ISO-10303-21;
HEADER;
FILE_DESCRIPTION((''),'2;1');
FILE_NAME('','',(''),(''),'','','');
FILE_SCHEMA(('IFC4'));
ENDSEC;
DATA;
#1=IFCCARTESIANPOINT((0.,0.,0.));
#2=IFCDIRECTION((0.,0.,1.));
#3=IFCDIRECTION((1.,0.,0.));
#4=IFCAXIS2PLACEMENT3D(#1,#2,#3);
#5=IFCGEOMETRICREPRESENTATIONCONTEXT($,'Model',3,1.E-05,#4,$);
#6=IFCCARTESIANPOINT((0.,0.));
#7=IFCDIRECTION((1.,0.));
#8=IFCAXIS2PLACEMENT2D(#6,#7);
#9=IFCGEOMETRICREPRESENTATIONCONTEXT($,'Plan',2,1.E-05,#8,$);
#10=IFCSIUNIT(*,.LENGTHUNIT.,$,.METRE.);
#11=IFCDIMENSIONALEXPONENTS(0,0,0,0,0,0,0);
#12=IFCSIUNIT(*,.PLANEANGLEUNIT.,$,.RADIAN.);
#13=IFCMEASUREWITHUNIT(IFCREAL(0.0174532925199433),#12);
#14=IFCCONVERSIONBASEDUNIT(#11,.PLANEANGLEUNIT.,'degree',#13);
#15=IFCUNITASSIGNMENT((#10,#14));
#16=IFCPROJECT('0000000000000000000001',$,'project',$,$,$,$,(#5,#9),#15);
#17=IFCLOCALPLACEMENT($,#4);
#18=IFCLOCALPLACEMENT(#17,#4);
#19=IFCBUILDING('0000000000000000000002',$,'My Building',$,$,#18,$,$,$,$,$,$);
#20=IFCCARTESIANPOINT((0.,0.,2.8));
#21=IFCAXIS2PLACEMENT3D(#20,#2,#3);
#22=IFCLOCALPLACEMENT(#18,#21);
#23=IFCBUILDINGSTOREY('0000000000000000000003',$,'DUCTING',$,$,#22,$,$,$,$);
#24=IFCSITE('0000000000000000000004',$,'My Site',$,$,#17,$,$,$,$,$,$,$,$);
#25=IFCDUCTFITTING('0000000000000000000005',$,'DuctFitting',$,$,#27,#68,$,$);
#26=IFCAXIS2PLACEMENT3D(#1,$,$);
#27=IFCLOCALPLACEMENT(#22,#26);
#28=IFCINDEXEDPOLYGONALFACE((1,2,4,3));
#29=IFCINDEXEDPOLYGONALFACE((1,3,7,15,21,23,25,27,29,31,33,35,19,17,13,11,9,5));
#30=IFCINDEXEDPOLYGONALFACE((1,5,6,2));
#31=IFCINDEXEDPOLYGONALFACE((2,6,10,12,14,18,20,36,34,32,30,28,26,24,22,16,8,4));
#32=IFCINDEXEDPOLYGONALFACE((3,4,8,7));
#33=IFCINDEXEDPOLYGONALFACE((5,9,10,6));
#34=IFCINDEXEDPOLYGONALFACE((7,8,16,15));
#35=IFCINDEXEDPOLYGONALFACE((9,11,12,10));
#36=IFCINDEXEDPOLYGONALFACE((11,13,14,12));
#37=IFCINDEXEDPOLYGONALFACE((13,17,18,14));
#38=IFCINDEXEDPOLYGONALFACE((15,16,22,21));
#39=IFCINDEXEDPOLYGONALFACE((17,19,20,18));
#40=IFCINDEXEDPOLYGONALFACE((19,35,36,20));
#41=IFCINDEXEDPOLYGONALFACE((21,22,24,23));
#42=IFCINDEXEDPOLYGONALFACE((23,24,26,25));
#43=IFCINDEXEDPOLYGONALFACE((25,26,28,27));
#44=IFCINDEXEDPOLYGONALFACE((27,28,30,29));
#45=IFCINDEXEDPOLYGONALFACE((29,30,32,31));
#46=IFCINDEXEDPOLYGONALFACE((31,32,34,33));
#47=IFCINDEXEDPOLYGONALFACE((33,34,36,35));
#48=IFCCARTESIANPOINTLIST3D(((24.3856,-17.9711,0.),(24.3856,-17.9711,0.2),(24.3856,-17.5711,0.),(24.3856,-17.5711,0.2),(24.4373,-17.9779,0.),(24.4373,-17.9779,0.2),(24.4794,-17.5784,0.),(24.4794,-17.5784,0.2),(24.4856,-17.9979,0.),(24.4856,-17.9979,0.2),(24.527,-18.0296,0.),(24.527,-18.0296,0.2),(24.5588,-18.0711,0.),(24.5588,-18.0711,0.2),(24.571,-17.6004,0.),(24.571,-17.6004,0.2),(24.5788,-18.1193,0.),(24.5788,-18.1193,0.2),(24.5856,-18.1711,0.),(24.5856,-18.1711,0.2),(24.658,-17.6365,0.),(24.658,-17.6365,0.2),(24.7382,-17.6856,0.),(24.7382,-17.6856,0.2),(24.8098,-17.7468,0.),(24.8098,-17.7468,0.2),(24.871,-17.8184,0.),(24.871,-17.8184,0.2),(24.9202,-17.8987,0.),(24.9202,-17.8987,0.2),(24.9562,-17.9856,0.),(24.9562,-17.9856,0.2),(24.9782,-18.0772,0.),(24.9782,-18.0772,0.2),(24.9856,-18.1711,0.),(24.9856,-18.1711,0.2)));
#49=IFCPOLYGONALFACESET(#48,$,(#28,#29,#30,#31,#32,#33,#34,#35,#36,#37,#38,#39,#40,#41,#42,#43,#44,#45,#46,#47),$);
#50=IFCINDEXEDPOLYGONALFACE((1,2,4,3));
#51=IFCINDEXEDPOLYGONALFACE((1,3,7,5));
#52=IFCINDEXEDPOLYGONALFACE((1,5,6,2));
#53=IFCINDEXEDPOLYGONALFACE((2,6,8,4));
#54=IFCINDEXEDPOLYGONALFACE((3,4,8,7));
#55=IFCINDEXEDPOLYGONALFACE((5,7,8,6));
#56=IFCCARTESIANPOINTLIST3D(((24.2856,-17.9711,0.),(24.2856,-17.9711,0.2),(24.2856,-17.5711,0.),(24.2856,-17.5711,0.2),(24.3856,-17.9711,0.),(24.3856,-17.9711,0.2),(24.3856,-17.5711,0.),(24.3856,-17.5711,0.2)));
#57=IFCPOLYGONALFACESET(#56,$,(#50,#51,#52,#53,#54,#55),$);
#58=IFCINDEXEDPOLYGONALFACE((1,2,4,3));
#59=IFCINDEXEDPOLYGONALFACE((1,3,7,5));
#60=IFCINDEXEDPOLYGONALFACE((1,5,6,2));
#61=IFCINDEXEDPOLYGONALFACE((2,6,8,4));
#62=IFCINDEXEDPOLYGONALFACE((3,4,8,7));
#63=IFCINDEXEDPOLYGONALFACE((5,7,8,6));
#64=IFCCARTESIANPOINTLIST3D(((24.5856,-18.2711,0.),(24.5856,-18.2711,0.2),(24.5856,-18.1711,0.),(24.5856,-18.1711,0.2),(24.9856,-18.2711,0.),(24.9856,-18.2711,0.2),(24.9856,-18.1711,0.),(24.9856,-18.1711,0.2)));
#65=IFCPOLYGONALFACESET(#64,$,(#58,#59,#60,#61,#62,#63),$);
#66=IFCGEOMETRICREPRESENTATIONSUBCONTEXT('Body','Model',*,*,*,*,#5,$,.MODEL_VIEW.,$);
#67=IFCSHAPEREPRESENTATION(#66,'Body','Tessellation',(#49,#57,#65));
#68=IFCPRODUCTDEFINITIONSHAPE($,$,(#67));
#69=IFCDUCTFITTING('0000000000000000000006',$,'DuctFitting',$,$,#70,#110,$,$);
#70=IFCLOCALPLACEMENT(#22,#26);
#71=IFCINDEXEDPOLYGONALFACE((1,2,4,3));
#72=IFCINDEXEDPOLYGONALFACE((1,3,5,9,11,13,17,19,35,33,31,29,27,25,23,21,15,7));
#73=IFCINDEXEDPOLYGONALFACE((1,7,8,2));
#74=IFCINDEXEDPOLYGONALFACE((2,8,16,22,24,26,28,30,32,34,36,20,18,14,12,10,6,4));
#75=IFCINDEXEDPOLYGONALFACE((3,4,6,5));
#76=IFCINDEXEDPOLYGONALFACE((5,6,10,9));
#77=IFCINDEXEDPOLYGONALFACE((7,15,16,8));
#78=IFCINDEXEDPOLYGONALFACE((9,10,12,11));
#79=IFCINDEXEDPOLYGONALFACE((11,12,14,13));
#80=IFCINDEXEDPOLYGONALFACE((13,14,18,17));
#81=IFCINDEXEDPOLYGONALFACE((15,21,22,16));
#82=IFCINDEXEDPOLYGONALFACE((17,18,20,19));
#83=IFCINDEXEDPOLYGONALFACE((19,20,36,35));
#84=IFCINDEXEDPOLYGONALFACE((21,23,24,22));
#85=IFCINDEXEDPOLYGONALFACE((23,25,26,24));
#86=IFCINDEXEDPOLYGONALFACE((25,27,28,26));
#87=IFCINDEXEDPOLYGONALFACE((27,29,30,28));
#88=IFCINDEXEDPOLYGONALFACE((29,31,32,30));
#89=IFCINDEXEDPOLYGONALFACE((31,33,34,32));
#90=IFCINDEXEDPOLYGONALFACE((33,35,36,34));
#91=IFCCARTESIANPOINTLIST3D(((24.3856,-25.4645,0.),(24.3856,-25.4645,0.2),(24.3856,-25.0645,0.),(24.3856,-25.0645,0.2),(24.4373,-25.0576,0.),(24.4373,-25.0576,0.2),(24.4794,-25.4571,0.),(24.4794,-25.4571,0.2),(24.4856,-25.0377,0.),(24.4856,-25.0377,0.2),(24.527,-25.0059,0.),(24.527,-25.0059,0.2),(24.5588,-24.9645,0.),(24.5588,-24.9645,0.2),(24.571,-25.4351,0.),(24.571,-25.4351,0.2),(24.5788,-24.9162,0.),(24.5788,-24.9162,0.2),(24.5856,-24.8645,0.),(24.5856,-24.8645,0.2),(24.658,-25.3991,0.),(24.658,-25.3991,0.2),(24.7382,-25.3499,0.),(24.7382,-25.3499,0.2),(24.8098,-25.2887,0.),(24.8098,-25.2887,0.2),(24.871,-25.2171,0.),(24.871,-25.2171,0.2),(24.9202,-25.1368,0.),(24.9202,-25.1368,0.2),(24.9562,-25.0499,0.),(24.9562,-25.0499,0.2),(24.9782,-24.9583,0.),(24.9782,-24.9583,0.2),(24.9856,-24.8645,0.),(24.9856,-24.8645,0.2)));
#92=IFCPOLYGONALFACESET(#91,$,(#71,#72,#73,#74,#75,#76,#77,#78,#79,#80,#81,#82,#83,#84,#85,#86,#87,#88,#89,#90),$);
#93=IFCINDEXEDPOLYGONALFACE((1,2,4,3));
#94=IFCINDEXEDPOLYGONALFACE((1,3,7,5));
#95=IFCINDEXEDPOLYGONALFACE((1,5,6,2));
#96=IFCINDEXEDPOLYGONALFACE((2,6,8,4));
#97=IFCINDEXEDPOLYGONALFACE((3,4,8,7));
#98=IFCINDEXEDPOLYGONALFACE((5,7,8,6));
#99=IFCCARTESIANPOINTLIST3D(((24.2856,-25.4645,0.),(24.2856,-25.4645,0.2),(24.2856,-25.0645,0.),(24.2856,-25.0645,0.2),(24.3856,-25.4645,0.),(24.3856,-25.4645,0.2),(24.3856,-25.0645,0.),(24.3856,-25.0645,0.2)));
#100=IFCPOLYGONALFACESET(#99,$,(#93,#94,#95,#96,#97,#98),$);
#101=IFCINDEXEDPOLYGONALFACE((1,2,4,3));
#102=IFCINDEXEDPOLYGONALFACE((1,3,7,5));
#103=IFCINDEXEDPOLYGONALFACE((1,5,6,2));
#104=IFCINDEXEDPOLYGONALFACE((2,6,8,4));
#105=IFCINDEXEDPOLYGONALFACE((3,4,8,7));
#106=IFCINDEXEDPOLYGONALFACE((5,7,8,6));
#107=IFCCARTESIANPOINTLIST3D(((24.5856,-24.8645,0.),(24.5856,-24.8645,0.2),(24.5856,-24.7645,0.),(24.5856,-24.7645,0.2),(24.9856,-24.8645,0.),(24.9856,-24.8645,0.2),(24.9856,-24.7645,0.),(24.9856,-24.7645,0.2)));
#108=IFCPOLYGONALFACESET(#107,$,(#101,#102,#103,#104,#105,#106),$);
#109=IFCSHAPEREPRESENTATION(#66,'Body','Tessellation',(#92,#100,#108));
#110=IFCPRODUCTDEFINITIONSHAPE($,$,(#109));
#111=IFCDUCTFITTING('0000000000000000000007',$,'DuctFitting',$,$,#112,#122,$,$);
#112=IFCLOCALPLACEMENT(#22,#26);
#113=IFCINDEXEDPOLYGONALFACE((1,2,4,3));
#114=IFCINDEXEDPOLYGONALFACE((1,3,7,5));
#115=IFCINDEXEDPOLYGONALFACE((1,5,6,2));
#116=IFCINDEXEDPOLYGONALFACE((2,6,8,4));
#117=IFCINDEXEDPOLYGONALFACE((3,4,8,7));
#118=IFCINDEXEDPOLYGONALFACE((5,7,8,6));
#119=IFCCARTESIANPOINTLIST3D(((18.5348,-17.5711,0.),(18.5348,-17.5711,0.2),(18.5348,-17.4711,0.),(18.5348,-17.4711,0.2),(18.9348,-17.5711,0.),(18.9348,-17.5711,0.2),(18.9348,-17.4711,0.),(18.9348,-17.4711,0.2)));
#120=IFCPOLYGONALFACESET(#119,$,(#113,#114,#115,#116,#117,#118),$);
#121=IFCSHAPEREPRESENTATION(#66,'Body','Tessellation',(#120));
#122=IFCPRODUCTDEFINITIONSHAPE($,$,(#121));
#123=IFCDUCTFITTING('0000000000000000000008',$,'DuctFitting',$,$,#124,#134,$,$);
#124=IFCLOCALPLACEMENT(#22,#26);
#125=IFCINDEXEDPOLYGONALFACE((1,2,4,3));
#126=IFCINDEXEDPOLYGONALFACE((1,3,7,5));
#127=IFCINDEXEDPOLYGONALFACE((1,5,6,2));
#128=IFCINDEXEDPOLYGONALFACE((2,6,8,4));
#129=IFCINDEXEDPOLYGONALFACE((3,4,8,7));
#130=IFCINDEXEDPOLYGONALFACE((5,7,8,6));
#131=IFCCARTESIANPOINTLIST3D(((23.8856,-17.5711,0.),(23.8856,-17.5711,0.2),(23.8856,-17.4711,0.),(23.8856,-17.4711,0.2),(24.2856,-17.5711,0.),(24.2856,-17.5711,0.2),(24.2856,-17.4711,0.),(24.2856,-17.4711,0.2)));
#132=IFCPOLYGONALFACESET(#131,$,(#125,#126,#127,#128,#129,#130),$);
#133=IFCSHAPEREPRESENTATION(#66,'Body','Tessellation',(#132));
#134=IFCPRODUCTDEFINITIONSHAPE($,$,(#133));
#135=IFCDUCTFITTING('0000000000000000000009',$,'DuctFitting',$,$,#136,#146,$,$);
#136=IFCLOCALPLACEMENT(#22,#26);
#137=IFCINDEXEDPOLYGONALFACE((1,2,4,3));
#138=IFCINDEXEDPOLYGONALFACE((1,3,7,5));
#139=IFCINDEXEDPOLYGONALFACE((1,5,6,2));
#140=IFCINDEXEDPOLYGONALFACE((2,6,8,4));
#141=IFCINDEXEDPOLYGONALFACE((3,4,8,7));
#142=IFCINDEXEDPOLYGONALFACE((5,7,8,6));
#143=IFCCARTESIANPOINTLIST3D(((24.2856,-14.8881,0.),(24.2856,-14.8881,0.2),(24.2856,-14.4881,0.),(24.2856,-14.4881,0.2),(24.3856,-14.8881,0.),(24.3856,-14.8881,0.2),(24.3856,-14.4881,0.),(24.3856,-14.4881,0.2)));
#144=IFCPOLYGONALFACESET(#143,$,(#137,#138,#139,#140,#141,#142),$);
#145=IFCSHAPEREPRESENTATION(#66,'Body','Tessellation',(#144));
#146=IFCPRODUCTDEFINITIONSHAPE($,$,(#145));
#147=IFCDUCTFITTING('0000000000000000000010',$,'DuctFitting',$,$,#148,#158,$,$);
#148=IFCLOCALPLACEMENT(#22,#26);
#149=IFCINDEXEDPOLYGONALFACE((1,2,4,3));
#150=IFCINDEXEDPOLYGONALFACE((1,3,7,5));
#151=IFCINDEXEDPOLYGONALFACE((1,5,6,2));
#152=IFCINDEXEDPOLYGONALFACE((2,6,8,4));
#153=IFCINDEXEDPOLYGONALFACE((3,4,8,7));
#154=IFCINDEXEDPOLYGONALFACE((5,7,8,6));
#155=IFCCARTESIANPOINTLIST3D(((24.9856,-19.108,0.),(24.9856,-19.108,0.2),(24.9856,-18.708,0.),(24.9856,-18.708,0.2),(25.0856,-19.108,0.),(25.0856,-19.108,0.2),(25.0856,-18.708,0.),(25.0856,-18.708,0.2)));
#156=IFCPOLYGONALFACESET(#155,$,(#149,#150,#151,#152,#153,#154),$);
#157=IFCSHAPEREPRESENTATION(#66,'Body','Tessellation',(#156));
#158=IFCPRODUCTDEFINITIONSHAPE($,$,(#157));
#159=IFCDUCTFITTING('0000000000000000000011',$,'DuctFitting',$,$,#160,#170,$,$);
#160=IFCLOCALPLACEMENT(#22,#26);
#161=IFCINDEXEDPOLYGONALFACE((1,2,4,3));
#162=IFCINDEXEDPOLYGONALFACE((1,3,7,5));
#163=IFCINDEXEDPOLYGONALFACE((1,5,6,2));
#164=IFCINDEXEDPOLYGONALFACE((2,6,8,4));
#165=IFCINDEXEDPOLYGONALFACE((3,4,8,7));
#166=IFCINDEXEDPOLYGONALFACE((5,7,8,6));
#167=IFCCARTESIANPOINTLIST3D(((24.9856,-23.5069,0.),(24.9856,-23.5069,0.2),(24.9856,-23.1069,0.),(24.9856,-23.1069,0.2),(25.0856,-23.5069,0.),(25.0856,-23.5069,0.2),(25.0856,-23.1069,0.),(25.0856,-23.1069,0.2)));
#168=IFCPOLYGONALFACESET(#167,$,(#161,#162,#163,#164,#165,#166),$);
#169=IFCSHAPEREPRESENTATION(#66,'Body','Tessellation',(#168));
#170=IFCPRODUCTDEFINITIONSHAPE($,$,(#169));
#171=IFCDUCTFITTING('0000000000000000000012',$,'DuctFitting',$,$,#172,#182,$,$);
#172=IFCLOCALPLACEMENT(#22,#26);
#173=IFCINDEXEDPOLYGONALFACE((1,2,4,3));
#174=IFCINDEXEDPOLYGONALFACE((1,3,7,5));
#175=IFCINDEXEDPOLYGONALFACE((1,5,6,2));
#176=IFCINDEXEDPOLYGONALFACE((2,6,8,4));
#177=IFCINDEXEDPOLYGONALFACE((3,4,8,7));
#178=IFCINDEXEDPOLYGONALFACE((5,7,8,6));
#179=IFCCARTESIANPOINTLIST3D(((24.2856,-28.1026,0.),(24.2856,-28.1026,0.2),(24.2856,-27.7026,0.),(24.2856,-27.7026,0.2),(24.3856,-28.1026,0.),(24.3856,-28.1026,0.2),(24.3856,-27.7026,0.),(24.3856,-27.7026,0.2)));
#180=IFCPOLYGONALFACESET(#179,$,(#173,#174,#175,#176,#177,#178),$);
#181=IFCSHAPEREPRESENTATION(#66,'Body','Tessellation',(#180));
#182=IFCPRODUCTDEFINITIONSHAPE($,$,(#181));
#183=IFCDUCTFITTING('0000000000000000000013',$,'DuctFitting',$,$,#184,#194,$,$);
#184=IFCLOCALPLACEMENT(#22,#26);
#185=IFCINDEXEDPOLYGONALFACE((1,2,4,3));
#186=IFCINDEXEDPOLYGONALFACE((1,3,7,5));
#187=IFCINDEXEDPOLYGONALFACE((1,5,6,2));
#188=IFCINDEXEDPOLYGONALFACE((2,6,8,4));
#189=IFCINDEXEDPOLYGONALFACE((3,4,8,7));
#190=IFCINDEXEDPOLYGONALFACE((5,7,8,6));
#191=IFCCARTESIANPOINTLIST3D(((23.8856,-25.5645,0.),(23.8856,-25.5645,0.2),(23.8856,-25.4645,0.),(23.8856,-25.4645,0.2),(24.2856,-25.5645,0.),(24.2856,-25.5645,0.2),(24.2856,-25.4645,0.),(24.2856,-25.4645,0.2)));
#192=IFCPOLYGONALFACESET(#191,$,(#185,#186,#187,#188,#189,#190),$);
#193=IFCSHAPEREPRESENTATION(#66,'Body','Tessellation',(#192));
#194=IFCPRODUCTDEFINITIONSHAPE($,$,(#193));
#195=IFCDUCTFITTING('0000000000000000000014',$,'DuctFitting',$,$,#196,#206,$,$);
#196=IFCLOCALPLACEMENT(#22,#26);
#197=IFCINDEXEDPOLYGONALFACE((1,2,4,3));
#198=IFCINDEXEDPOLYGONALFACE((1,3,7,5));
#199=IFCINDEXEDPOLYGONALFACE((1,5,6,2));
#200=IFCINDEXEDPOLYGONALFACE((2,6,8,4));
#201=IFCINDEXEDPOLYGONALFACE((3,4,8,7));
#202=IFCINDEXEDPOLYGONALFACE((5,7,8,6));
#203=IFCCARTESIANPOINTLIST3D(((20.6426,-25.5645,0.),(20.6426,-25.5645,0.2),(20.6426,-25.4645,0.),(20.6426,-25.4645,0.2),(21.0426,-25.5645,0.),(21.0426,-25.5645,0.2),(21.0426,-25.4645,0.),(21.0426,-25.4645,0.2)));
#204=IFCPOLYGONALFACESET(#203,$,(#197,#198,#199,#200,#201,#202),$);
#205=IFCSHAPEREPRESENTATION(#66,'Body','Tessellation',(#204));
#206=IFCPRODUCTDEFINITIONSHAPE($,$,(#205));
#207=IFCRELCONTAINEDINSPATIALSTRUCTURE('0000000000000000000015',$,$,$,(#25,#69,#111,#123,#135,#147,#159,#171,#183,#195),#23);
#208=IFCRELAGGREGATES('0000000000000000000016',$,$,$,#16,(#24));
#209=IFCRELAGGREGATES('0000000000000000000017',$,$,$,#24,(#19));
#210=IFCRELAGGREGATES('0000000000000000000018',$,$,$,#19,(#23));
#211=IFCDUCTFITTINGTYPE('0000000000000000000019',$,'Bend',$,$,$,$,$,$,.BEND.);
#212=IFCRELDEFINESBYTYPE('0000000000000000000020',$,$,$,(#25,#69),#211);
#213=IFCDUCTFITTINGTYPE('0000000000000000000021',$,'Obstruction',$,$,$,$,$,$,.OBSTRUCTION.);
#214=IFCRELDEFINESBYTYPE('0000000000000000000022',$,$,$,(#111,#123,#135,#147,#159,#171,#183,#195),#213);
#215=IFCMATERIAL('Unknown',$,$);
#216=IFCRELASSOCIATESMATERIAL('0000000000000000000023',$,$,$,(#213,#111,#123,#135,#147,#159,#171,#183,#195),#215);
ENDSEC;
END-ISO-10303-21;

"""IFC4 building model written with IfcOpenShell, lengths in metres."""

from ifc_helpers import new_model, entity, si_unit, converted_unit, frame, origin_with_axes, origin_2d_with_axis, place, context, subcontext, project, spatial, line, arc, indexed_curve, rectangle, outline, extrude, source, transform, mapped, material, material_profile, profile_set, profile_usage, type_object, type_shapes, element, save


model = new_model("IFC4")

# Units and contexts
model_context = context("Model", 3, precision=1e-05, world=origin_with_axes())
plan_context = context("Plan", 2, precision=1e-05, world=origin_2d_with_axis())
body_context = subcontext(model_context, "Body", "Model", "MODEL_VIEW")
ifc_project = project(units=[si_unit("LENGTHUNIT", "METRE"), converted_unit("PLANEANGLEUNIT", "degree", entity("IfcReal", 0.0174532925199433), si_unit("PLANEANGLEUNIT", "RADIAN"), dimensions=[0, 0, 0, 0, 0, 0, 0])], contexts=[model_context, plan_context])

# Site, building, storey
site_placement = place(None, origin_with_axes())
site = spatial("IfcSite", under=ifc_project, at=site_placement, Name="My Site")
building_placement = place(site_placement, origin_with_axes())
building = spatial("IfcBuilding", under=site, at=building_placement, Name="My Building")
storey_placement = place(building_placement, frame((0.0, 0.0, 2.8), z_axis=(0.0, 0.0, 1.0), x_axis=(1.0, 0.0, 0.0)))
storey = spatial("IfcBuildingStorey", under=building, at=storey_placement, Name="DUCTING")

# Shared definitions
ifc_material = material(Name="Unknown")

# Duct fittings
duct_fitting_type_1 = type_object("IfcDuctFittingType", Name="Bend", PredefinedType="BEND")
shared_shape = source(origin_with_axes(), body_context, "Body", "SweptSolid", [
    extrude(outline(indexed_curve([(0.2, 0.0), (0.2586, -0.1414), (0.4, -0.2), (0.4, -0.6), (-0.0243, -0.4243), (-0.2, 0.0)], segments=[arc(1, 2, 3), line(3, 4), arc(4, 5, 6), line(6, 1)])), frame((0.0, -0.1, -0.1), z_axis=(0.0, -1.0, 0.0), x_axis=(1.0, 0.0, 0.0)), (0.0, 0.0, -1.0), 0.2),
    extrude(rectangle(XDim=0.4, YDim=0.2), origin_with_axes(), (0.0, 0.0, -1.0), 0.1),
    extrude(rectangle(XDim=0.4, YDim=0.2), frame((0.4, 0.0, -0.5), z_axis=(1.0, 0.0, 0.0), x_axis=(0.0, 0.0, 1.0)), (0.0, 0.0, 1.0), 0.1),
])
type_shapes(duct_fitting_type_1, [shared_shape])
for number, where, z_axis, x_axis, name in (
    (1, (24.2856, -17.7711, 0.1), (-1.0, 0.0, 0.0), (0.0, -1.0, 0.0), "DuctFitting"),
    (2, (24.2856, -25.2645, 0.1), (-1.0, 0.0, 0.0), (0.0, 1.0, 0.0), "DuctFitting"),
):
    element("IfcDuctFitting", number, at=place(storey_placement, frame(where, z_axis=z_axis, x_axis=x_axis)), inside=storey, type_object=duct_fitting_type_1, Name=name, context=body_context, shape_type="MappedRepresentation", body=[
        mapped(shared_shape, transform((0.0, 0.0, 0.0), x_axis=(1.0, 0.0, 0.0), y_axis=(0.0, 1.0, 0.0), z_axis=(0.0, 0.0, 1.0), scale=1.0)),
    ])
ifc_material_profile_1 = material_profile(ifc_material, rectangle(XDim=0.4, YDim=0.2))
ifc_profile_set_1 = profile_set([ifc_material_profile_1])
ifc_profile_usage_1 = profile_usage(ifc_profile_set_1, cardinal=5)
duct_fitting_type_2 = type_object("IfcDuctFittingType", Name="Obstruction", PredefinedType="OBSTRUCTION", material=ifc_profile_set_1)
duct_fitting_1_placement = place(storey_placement, frame((18.7348, -17.5711, 0.1), z_axis=(0.0, 1.0, 0.0), x_axis=(-1.0, 0.0, 0.0)))
element("IfcDuctFitting", 3, at=duct_fitting_1_placement, inside=storey, type_object=duct_fitting_type_2, material=ifc_profile_usage_1, Name="DuctFitting", context=body_context, shape_type="SweptSolid", body=[
    extrude(rectangle(XDim=0.4, YDim=0.2), origin_with_axes(), (0.0, 0.0, 1.0), 0.1),
])
ifc_profile_usage_2 = profile_usage(ifc_profile_set_1, cardinal=5)
duct_fitting_2_placement = place(storey_placement, frame((24.0856, -17.5711, 0.1), z_axis=(0.0, 1.0, 0.0), x_axis=(-1.0, 0.0, 0.0)))
element("IfcDuctFitting", 4, at=duct_fitting_2_placement, inside=storey, type_object=duct_fitting_type_2, material=ifc_profile_usage_2, Name="DuctFitting", context=body_context, shape_type="SweptSolid", body=[
    extrude(rectangle(XDim=0.4, YDim=0.2), origin_with_axes(), (0.0, 0.0, 1.0), 0.1),
])
ifc_profile_usage_3 = profile_usage(ifc_profile_set_1, cardinal=5)
duct_fitting_3_placement = place(storey_placement, frame((24.2856, -14.6881, 0.1), z_axis=(1.0, 0.0, 0.0), x_axis=(0.0, 1.0, 0.0)))
element("IfcDuctFitting", 5, at=duct_fitting_3_placement, inside=storey, type_object=duct_fitting_type_2, material=ifc_profile_usage_3, Name="DuctFitting", context=body_context, shape_type="SweptSolid", body=[
    extrude(rectangle(XDim=0.4, YDim=0.2), origin_with_axes(), (0.0, 0.0, 1.0), 0.1),
])
ifc_profile_usage_4 = profile_usage(ifc_profile_set_1, cardinal=5)
duct_fitting_4_placement = place(storey_placement, frame((24.9856, -18.908, 0.1), z_axis=(1.0, 0.0, 0.0), x_axis=(0.0, 1.0, 0.0)))
element("IfcDuctFitting", 6, at=duct_fitting_4_placement, inside=storey, type_object=duct_fitting_type_2, material=ifc_profile_usage_4, Name="DuctFitting", context=body_context, shape_type="SweptSolid", body=[
    extrude(rectangle(XDim=0.4, YDim=0.2), origin_with_axes(), (0.0, 0.0, 1.0), 0.1),
])
ifc_profile_usage_5 = profile_usage(ifc_profile_set_1, cardinal=5)
duct_fitting_5_placement = place(storey_placement, frame((24.9856, -23.3069, 0.1), z_axis=(1.0, 0.0, 0.0), x_axis=(0.0, 1.0, 0.0)))
element("IfcDuctFitting", 7, at=duct_fitting_5_placement, inside=storey, type_object=duct_fitting_type_2, material=ifc_profile_usage_5, Name="DuctFitting", context=body_context, shape_type="SweptSolid", body=[
    extrude(rectangle(XDim=0.4, YDim=0.2), origin_with_axes(), (0.0, 0.0, 1.0), 0.1),
])
ifc_profile_usage_6 = profile_usage(ifc_profile_set_1, cardinal=5)
duct_fitting_6_placement = place(storey_placement, frame((24.2856, -27.9026, 0.1), z_axis=(1.0, 0.0, 0.0), x_axis=(0.0, 1.0, 0.0)))
element("IfcDuctFitting", 8, at=duct_fitting_6_placement, inside=storey, type_object=duct_fitting_type_2, material=ifc_profile_usage_6, Name="DuctFitting", context=body_context, shape_type="SweptSolid", body=[
    extrude(rectangle(XDim=0.4, YDim=0.2), origin_with_axes(), (0.0, 0.0, 1.0), 0.1),
])
ifc_profile_usage_7 = profile_usage(ifc_profile_set_1, cardinal=5)
duct_fitting_7_placement = place(storey_placement, frame((24.0856, -25.4645, 0.1), z_axis=(0.0, -1.0, 0.0), x_axis=(1.0, 0.0, 0.0)))
element("IfcDuctFitting", 9, at=duct_fitting_7_placement, inside=storey, type_object=duct_fitting_type_2, material=ifc_profile_usage_7, Name="DuctFitting", context=body_context, shape_type="SweptSolid", body=[
    extrude(rectangle(XDim=0.4, YDim=0.2), origin_with_axes(), (0.0, 0.0, 1.0), 0.1),
])
ifc_profile_usage_8 = profile_usage(ifc_profile_set_1, cardinal=5)
duct_fitting_8_placement = place(storey_placement, frame((20.8426, -25.5645, 0.1), z_axis=(0.0, 1.0, 0.0), x_axis=(-1.0, 0.0, 0.0)))
element("IfcDuctFitting", 10, at=duct_fitting_8_placement, inside=storey, type_object=duct_fitting_type_2, material=ifc_profile_usage_8, Name="DuctFitting", context=body_context, shape_type="SweptSolid", body=[
    extrude(rectangle(XDim=0.4, YDim=0.2), origin_with_axes(), (0.0, 0.0, 1.0), 0.1),
])

save(model, "model.ifc")
